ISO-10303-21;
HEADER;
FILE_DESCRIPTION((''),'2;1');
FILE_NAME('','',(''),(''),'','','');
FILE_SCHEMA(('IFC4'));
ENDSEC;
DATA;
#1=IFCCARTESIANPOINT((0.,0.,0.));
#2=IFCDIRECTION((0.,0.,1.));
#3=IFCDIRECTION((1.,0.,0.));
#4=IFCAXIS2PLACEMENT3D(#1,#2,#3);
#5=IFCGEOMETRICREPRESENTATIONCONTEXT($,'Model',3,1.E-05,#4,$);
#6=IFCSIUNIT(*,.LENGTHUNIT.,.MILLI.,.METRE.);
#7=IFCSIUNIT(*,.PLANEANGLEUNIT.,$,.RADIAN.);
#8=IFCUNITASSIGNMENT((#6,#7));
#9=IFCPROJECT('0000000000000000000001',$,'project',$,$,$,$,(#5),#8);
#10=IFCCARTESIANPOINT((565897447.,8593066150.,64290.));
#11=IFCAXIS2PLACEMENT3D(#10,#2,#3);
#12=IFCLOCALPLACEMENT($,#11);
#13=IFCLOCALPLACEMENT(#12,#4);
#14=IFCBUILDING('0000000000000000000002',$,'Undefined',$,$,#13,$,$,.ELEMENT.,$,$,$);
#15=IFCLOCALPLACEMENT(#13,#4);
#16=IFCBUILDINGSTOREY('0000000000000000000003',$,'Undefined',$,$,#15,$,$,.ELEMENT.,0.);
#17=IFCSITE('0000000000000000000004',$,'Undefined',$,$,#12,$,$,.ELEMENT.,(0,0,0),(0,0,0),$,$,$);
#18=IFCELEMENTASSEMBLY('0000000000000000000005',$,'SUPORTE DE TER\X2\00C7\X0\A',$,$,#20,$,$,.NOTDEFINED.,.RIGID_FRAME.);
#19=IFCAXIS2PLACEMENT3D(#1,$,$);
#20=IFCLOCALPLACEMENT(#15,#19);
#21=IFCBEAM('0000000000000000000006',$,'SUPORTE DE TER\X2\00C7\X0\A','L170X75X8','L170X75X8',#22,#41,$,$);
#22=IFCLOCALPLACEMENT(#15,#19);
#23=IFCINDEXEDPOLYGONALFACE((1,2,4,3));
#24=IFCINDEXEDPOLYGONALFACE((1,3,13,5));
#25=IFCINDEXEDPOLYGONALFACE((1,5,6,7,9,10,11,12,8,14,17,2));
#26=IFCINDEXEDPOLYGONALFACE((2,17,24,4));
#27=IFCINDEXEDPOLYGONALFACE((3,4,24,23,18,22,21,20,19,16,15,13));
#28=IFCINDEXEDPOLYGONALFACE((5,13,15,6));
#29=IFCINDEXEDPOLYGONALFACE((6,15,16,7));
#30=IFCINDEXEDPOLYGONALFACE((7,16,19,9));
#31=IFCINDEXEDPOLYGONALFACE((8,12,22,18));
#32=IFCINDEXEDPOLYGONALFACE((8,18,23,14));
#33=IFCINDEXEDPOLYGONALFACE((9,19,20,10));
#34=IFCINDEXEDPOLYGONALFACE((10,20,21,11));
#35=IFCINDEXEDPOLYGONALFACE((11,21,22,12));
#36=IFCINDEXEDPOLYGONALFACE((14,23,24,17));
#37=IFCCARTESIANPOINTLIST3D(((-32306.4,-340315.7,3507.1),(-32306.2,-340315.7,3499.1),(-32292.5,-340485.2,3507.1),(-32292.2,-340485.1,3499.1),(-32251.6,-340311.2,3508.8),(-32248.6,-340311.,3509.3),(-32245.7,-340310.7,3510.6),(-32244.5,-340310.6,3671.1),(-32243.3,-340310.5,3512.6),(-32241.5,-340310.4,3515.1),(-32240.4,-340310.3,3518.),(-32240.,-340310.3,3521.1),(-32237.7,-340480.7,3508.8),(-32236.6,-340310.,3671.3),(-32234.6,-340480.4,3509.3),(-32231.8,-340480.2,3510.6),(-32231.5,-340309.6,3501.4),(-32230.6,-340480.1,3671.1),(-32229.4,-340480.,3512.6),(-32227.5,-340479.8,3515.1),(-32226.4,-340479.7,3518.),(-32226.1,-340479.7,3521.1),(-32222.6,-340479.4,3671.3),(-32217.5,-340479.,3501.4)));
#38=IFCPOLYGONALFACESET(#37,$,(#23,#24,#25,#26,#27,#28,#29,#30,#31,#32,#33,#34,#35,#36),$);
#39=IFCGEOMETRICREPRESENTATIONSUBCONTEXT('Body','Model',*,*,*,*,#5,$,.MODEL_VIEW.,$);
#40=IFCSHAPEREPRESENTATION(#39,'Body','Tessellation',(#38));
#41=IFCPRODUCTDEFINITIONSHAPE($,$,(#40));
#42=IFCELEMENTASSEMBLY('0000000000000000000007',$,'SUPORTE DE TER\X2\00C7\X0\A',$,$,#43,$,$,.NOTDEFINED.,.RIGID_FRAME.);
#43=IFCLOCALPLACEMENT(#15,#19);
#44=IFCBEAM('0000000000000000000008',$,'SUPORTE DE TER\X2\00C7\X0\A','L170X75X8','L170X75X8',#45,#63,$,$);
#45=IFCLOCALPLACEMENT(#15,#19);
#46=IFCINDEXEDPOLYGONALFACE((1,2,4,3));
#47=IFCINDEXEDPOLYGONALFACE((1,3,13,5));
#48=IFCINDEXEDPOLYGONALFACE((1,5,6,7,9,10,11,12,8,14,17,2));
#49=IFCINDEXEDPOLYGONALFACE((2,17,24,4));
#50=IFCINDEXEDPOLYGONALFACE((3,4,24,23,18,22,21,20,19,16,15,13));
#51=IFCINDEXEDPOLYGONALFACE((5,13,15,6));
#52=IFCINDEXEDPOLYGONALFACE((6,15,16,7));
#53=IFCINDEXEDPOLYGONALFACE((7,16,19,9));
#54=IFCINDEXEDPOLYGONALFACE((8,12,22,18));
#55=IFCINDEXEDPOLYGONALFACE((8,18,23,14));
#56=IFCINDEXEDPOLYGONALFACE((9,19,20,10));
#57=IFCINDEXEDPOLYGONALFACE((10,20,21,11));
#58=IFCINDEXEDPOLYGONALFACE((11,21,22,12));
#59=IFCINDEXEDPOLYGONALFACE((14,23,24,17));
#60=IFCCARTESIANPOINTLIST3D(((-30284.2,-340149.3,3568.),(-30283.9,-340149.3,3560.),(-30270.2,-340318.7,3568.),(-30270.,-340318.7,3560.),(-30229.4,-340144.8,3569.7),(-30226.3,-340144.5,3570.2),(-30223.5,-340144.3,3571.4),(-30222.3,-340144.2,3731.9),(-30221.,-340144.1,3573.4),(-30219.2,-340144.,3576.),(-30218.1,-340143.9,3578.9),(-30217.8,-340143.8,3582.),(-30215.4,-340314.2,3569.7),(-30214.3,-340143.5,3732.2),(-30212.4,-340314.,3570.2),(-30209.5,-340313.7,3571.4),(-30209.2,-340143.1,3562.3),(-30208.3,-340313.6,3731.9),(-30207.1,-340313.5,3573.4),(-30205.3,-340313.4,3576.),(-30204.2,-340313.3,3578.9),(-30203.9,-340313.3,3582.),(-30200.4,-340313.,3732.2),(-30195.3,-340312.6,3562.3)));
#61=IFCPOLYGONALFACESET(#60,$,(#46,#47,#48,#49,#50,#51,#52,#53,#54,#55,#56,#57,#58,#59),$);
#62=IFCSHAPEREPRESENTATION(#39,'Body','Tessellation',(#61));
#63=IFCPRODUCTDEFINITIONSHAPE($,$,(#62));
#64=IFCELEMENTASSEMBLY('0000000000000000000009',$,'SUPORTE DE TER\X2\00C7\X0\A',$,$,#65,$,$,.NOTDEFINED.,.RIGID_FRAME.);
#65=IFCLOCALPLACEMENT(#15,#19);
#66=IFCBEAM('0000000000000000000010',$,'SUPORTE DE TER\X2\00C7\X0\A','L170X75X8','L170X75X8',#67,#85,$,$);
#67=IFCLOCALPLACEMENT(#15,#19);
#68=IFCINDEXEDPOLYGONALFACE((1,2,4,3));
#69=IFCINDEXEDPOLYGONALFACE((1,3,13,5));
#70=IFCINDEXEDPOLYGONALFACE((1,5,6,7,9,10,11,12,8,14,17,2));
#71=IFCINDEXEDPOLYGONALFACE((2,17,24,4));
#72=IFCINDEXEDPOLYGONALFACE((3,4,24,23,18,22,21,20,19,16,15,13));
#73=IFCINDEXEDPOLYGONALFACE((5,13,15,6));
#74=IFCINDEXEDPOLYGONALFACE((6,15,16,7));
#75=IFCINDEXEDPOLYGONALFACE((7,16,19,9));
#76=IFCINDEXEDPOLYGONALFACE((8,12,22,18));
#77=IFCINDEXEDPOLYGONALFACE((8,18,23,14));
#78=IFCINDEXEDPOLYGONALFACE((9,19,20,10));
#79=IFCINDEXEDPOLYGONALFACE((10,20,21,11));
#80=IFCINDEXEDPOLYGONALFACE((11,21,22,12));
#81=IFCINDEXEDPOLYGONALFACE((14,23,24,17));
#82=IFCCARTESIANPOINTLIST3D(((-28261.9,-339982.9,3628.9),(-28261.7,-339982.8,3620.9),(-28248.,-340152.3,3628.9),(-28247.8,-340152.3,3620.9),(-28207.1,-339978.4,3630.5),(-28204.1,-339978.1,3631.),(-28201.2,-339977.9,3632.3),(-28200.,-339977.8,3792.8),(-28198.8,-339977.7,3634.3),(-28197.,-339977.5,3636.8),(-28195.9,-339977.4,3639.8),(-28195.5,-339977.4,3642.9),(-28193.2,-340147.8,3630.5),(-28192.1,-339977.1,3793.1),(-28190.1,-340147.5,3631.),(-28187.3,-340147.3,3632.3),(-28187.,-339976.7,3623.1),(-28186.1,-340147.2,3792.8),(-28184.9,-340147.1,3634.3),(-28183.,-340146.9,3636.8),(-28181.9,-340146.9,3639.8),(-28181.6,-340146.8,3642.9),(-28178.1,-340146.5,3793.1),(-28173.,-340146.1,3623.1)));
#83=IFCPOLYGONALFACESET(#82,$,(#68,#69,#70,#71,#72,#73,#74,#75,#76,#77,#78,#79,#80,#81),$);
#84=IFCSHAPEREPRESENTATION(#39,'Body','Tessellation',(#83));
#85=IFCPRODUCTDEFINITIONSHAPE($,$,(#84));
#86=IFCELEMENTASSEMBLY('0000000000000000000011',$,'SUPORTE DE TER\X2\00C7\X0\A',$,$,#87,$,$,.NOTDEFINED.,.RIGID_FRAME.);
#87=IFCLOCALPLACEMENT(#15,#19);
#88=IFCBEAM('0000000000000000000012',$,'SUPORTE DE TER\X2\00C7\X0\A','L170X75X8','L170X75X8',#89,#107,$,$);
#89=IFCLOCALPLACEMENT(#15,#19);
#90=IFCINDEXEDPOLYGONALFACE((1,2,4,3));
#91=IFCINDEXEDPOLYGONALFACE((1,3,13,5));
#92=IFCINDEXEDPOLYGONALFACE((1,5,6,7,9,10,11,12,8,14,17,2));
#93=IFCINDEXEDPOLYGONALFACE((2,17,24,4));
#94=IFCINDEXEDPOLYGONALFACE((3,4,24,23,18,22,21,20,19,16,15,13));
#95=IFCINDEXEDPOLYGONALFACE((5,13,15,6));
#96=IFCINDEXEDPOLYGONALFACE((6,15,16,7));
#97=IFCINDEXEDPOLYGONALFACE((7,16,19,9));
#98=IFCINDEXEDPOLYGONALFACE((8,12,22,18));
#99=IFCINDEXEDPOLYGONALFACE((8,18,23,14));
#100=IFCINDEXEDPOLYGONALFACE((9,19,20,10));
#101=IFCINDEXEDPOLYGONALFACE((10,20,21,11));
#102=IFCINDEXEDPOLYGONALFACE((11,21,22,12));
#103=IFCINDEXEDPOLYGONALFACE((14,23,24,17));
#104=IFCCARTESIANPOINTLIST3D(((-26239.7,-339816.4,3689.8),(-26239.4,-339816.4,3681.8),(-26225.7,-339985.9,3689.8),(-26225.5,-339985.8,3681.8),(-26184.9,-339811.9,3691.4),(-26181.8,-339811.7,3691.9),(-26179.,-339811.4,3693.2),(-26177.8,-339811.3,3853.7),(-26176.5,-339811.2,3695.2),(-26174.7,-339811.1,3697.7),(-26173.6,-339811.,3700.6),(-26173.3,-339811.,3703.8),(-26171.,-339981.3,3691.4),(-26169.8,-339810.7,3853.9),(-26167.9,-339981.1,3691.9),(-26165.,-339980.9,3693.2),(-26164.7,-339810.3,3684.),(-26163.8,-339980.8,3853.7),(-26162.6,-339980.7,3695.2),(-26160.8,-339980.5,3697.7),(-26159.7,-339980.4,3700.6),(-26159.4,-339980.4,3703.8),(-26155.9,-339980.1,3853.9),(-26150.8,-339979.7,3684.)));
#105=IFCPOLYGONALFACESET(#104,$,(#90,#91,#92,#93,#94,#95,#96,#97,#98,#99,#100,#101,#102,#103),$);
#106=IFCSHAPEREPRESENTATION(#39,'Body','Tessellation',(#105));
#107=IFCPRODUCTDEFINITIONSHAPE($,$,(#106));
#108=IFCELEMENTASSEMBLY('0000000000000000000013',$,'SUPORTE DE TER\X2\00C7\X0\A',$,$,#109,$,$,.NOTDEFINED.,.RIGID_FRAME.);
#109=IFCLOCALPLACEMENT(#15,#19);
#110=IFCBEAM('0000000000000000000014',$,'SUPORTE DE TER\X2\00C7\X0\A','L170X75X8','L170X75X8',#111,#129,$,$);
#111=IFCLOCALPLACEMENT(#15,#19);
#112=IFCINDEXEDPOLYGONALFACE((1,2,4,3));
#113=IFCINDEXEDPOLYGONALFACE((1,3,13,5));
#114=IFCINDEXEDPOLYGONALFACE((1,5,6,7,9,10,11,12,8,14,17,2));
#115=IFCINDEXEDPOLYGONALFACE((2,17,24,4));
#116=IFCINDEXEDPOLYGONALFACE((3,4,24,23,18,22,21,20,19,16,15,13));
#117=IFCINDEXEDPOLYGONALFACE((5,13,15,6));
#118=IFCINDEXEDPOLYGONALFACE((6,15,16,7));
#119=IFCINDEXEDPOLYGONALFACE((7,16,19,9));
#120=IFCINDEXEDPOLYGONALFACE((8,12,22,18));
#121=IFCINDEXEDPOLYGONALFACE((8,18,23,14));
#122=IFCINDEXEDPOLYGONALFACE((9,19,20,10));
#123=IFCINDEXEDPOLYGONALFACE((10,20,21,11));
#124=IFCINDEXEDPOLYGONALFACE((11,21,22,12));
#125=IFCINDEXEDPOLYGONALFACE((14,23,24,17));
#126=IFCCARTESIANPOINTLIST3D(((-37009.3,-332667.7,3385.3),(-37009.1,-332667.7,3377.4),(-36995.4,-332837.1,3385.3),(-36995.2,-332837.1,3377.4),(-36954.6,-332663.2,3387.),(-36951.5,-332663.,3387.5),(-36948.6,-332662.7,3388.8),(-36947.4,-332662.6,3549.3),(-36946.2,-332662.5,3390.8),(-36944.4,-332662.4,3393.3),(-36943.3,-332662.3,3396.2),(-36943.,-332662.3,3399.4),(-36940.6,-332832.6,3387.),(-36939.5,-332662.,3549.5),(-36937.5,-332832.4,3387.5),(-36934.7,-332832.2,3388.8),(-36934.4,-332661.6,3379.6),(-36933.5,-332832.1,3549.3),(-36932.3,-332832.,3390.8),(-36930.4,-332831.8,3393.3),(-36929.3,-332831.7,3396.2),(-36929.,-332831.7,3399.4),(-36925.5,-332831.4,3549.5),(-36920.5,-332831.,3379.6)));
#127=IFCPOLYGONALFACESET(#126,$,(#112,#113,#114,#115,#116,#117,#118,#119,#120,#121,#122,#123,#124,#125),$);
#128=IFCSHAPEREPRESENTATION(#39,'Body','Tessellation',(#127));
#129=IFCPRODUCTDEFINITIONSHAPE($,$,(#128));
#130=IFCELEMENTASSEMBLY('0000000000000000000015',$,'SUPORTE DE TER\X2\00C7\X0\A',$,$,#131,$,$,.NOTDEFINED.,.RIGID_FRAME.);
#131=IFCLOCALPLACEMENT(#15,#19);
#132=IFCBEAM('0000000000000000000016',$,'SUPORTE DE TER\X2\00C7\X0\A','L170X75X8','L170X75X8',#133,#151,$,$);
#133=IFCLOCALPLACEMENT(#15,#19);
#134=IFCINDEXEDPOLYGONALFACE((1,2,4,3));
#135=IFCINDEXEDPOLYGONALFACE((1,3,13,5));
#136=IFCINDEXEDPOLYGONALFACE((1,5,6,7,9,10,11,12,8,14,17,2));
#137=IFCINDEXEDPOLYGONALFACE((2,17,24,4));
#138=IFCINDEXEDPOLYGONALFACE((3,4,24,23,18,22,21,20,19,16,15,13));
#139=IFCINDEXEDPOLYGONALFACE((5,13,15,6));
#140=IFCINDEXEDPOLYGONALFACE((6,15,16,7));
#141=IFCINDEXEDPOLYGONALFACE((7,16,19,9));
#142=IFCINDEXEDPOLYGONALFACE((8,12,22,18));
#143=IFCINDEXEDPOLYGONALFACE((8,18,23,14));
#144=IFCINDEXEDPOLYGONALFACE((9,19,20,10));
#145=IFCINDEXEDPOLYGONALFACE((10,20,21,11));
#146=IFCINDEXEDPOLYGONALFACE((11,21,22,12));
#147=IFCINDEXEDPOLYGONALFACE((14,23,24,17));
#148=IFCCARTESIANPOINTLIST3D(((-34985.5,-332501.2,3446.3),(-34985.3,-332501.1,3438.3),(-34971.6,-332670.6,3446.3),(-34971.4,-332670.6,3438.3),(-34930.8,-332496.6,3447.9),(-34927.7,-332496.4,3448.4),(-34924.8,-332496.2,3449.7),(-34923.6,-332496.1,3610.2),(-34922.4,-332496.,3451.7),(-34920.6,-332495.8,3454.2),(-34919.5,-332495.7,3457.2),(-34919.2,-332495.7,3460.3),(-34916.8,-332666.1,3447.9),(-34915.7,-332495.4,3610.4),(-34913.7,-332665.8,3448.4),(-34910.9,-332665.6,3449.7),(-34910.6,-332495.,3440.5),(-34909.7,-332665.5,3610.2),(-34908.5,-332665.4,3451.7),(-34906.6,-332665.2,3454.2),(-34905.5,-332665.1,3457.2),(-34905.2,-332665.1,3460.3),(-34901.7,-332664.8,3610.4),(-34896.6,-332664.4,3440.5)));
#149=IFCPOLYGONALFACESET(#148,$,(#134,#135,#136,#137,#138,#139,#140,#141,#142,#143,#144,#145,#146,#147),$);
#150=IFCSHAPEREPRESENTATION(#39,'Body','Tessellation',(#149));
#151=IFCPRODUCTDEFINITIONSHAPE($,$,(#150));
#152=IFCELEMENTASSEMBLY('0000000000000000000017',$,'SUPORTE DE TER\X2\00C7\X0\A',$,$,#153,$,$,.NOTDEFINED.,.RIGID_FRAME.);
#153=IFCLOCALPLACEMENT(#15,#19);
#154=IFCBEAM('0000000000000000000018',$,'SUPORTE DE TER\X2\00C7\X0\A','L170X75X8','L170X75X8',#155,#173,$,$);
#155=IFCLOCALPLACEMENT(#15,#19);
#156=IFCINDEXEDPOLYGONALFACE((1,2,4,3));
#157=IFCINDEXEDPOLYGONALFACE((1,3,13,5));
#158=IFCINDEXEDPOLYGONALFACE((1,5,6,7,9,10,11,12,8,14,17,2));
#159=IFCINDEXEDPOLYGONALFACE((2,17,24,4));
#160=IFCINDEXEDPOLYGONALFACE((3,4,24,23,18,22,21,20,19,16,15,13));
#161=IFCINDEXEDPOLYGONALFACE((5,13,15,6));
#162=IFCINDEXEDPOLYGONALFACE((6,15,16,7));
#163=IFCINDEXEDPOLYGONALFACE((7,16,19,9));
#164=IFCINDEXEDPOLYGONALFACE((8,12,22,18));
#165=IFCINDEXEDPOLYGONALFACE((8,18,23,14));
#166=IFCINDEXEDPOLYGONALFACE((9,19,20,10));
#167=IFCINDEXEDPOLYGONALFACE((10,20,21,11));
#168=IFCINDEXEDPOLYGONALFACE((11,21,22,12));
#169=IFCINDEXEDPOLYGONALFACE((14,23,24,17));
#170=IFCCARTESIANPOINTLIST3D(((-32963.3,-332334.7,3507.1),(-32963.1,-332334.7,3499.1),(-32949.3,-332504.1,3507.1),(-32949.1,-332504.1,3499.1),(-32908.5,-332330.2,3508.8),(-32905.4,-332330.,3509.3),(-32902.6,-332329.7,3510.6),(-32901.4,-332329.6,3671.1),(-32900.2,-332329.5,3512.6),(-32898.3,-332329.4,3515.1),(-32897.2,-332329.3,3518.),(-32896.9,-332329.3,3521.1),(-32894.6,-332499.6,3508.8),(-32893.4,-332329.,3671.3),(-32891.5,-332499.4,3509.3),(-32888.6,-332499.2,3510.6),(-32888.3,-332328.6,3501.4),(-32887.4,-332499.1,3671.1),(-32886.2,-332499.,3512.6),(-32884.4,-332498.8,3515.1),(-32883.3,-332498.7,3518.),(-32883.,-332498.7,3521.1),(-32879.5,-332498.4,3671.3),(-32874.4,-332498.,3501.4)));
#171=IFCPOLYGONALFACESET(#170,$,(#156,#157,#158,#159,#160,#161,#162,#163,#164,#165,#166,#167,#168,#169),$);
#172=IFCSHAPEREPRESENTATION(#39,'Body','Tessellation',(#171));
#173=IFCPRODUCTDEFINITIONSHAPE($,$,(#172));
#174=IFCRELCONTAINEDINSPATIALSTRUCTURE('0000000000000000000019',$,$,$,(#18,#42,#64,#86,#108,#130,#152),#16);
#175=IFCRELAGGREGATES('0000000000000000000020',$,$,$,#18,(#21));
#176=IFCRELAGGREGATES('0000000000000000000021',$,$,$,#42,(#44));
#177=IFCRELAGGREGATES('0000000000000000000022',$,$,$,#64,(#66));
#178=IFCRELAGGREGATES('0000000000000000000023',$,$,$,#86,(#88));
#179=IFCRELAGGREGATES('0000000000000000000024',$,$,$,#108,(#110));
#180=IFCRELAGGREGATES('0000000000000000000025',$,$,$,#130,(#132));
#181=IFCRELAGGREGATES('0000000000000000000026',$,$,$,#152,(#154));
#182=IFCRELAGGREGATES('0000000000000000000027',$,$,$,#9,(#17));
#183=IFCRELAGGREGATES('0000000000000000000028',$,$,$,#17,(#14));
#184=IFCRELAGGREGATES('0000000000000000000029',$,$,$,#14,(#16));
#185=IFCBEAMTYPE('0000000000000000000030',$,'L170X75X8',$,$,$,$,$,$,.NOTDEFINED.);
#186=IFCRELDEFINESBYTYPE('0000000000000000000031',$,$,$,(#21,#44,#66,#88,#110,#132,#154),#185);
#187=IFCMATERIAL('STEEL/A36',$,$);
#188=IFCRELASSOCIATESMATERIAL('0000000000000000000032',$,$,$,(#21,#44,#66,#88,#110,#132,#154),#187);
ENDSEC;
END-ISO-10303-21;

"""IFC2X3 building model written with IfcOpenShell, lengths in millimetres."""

from ifc_helpers import new_model, si_unit, frame, origin_with_axes, origin_2d_with_axis, place, context, subcontext, project, spatial, l_section, extrude, material, type_object, element, aggregate, save


model = new_model("IFC2X3")

# Units and contexts
model_context = context("Model", 3, precision=1e-05, world=origin_with_axes())
body_context = subcontext(model_context, "Body", "Model", "MODEL_VIEW")
ifc_project = project(units=[si_unit("LENGTHUNIT", "METRE", prefix="MILLI"), si_unit("PLANEANGLEUNIT", "RADIAN")], contexts=[model_context])

# Site, building, storey
site_placement = place(None, frame((565897447.0, 8593066150.0, 64290.0), z_axis=(0.0, 0.0, 1.0), x_axis=(1.0, 0.0, 0.0)))
site = spatial("IfcSite", under=ifc_project, at=site_placement, Name="Undefined", CompositionType="ELEMENT", RefLatitude=(0, 0, 0), RefLongitude=(0, 0, 0))
building_placement = place(site_placement, origin_with_axes())
building = spatial("IfcBuilding", under=site, at=building_placement, Name="Undefined", CompositionType="ELEMENT")
storey_placement = place(building_placement, origin_with_axes())
storey = spatial("IfcBuildingStorey", under=building, at=storey_placement, Name="Undefined", CompositionType="ELEMENT", Elevation=0.0)

# Element assemblies, beams
ifc_material_1 = material(Name="STEEL/A36")
beam_type_1 = type_object("IfcBeamType", Name="L170X75X8", PredefinedType="NOTDEFINED")
assembly_1_placement = place(storey_placement, origin_with_axes())
assembly_1 = element("IfcElementAssembly", 1, at=assembly_1_placement, inside=storey, Name="SUPORTE DE TERÇA", AssemblyPlace="NOTDEFINED", PredefinedType="RIGID_FRAME")
beam_1_placement = place(assembly_1_placement, frame((-32271.4, -340312.9, 3585.2), z_axis=(-0.029885, -0.00246, 0.99955), x_axis=(0.082025, -0.99663, 0.0)))
beam_1 = element("IfcBeam", 2, at=beam_1_placement, type_object=beam_type_1, material=ifc_material_1, Name="SUPORTE DE TERÇA", Description="L170X75X8", ObjectType="L170X75X8", context=body_context, shape_type="SweptSolid", body=[
    extrude(l_section(Depth=170.0, Width=75.0, Thickness=8.0, FilletRadius=12.0, at=origin_2d_with_axis()), frame((170.0, 0.0, 0.0), z_axis=(-1.0, 0.0, 0.0), x_axis=(0.0, -1.0, 0.0)), (0.0, 0.0, 1.0), 170.0),
])
aggregate(assembly_1, [beam_1])
assembly_2_placement = place(storey_placement, origin_with_axes())
assembly_2 = element("IfcElementAssembly", 3, at=assembly_2_placement, inside=storey, Name="SUPORTE DE TERÇA", AssemblyPlace="NOTDEFINED", PredefinedType="RIGID_FRAME")
beam_2_placement = place(assembly_2_placement, frame((-30249.1, -340146.4, 3646.1), z_axis=(-0.029885, -0.00246, 0.99955), x_axis=(0.082025, -0.99663, 0.0)))
beam_2 = element("IfcBeam", 4, at=beam_2_placement, type_object=beam_type_1, material=ifc_material_1, Name="SUPORTE DE TERÇA", Description="L170X75X8", ObjectType="L170X75X8", context=body_context, shape_type="SweptSolid", body=[
    extrude(l_section(Depth=170.0, Width=75.0, Thickness=8.0, FilletRadius=12.0, at=origin_2d_with_axis()), frame((170.0, 0.0, 0.0), z_axis=(-1.0, 0.0, 0.0), x_axis=(0.0, -1.0, 0.0)), (0.0, 0.0, 1.0), 170.0),
])
aggregate(assembly_2, [beam_2])
assembly_3_placement = place(storey_placement, origin_with_axes())
assembly_3 = element("IfcElementAssembly", 5, at=assembly_3_placement, inside=storey, Name="SUPORTE DE TERÇA", AssemblyPlace="NOTDEFINED", PredefinedType="RIGID_FRAME")
beam_3_placement = place(assembly_3_placement, frame((-28226.9, -339980.0, 3707.0), z_axis=(-0.029885, -0.00246, 0.99955), x_axis=(0.082025, -0.99663, 0.0)))
beam_3 = element("IfcBeam", 6, at=beam_3_placement, type_object=beam_type_1, material=ifc_material_1, Name="SUPORTE DE TERÇA", Description="L170X75X8", ObjectType="L170X75X8", context=body_context, shape_type="SweptSolid", body=[
    extrude(l_section(Depth=170.0, Width=75.0, Thickness=8.0, FilletRadius=12.0, at=origin_2d_with_axis()), frame((170.0, 0.0, 0.0), z_axis=(-1.0, 0.0, 0.0), x_axis=(0.0, -1.0, 0.0)), (0.0, 0.0, 1.0), 170.0),
])
aggregate(assembly_3, [beam_3])
assembly_4_placement = place(storey_placement, origin_with_axes())
assembly_4 = element("IfcElementAssembly", 7, at=assembly_4_placement, inside=storey, Name="SUPORTE DE TERÇA", AssemblyPlace="NOTDEFINED", PredefinedType="RIGID_FRAME")
beam_4_placement = place(assembly_4_placement, frame((-26204.6, -339813.5, 3767.8), z_axis=(-0.029885, -0.00246, 0.99955), x_axis=(0.082025, -0.99663, 0.0)))
beam_4 = element("IfcBeam", 8, at=beam_4_placement, type_object=beam_type_1, material=ifc_material_1, Name="SUPORTE DE TERÇA", Description="L170X75X8", ObjectType="L170X75X8", context=body_context, shape_type="SweptSolid", body=[
    extrude(l_section(Depth=170.0, Width=75.0, Thickness=8.0, FilletRadius=12.0, at=origin_2d_with_axis()), frame((170.0, 0.0, 0.0), z_axis=(-1.0, 0.0, 0.0), x_axis=(0.0, -1.0, 0.0)), (0.0, 0.0, 1.0), 170.0),
])
aggregate(assembly_4, [beam_4])
assembly_5_placement = place(storey_placement, origin_with_axes())
assembly_5 = element("IfcElementAssembly", 9, at=assembly_5_placement, inside=storey, Name="SUPORTE DE TERÇA", AssemblyPlace="NOTDEFINED", PredefinedType="RIGID_FRAME")
beam_5_placement = place(assembly_5_placement, frame((-36974.3, -332664.8, 3463.4), z_axis=(-0.029885, -0.00246, 0.99955), x_axis=(0.082025, -0.99663, 0.0)))
beam_5 = element("IfcBeam", 10, at=beam_5_placement, type_object=beam_type_1, material=ifc_material_1, Name="SUPORTE DE TERÇA", Description="L170X75X8", ObjectType="L170X75X8", context=body_context, shape_type="SweptSolid", body=[
    extrude(l_section(Depth=170.0, Width=75.0, Thickness=8.0, FilletRadius=12.0, at=origin_2d_with_axis()), frame((170.0, 0.0, 0.0), z_axis=(-1.0, 0.0, 0.0), x_axis=(0.0, -1.0, 0.0)), (0.0, 0.0, 1.0), 170.0),
])
aggregate(assembly_5, [beam_5])
assembly_6_placement = place(storey_placement, origin_with_axes())
assembly_6 = element("IfcElementAssembly", 11, at=assembly_6_placement, inside=storey, Name="SUPORTE DE TERÇA", AssemblyPlace="NOTDEFINED", PredefinedType="RIGID_FRAME")
beam_6_placement = place(assembly_6_placement, frame((-34950.5, -332498.3, 3524.4), z_axis=(-0.029885, -0.00246, 0.99955), x_axis=(0.082025, -0.99663, 0.0)))
beam_6 = element("IfcBeam", 12, at=beam_6_placement, type_object=beam_type_1, material=ifc_material_1, Name="SUPORTE DE TERÇA", Description="L170X75X8", ObjectType="L170X75X8", context=body_context, shape_type="SweptSolid", body=[
    extrude(l_section(Depth=170.0, Width=75.0, Thickness=8.0, FilletRadius=12.0, at=origin_2d_with_axis()), frame((170.0, 0.0, 0.0), z_axis=(-1.0, 0.0, 0.0), x_axis=(0.0, -1.0, 0.0)), (0.0, 0.0, 1.0), 170.0),
])
aggregate(assembly_6, [beam_6])
assembly_7_placement = place(storey_placement, origin_with_axes())
assembly_7 = element("IfcElementAssembly", 13, at=assembly_7_placement, inside=storey, Name="SUPORTE DE TERÇA", AssemblyPlace="NOTDEFINED", PredefinedType="RIGID_FRAME")
beam_7_placement = place(assembly_7_placement, frame((-32928.2, -332331.8, 3585.2), z_axis=(-0.029885, -0.00246, 0.99955), x_axis=(0.082025, -0.99663, 0.0)))
beam_7 = element("IfcBeam", 14, at=beam_7_placement, type_object=beam_type_1, material=ifc_material_1, Name="SUPORTE DE TERÇA", Description="L170X75X8", ObjectType="L170X75X8", context=body_context, shape_type="SweptSolid", body=[
    extrude(l_section(Depth=170.0, Width=75.0, Thickness=8.0, FilletRadius=12.0, at=origin_2d_with_axis()), frame((170.0, 0.0, 0.0), z_axis=(-1.0, 0.0, 0.0), x_axis=(0.0, -1.0, 0.0)), (0.0, 0.0, 1.0), 170.0),
])
aggregate(assembly_7, [beam_7])

save(model, "model.ifc")
